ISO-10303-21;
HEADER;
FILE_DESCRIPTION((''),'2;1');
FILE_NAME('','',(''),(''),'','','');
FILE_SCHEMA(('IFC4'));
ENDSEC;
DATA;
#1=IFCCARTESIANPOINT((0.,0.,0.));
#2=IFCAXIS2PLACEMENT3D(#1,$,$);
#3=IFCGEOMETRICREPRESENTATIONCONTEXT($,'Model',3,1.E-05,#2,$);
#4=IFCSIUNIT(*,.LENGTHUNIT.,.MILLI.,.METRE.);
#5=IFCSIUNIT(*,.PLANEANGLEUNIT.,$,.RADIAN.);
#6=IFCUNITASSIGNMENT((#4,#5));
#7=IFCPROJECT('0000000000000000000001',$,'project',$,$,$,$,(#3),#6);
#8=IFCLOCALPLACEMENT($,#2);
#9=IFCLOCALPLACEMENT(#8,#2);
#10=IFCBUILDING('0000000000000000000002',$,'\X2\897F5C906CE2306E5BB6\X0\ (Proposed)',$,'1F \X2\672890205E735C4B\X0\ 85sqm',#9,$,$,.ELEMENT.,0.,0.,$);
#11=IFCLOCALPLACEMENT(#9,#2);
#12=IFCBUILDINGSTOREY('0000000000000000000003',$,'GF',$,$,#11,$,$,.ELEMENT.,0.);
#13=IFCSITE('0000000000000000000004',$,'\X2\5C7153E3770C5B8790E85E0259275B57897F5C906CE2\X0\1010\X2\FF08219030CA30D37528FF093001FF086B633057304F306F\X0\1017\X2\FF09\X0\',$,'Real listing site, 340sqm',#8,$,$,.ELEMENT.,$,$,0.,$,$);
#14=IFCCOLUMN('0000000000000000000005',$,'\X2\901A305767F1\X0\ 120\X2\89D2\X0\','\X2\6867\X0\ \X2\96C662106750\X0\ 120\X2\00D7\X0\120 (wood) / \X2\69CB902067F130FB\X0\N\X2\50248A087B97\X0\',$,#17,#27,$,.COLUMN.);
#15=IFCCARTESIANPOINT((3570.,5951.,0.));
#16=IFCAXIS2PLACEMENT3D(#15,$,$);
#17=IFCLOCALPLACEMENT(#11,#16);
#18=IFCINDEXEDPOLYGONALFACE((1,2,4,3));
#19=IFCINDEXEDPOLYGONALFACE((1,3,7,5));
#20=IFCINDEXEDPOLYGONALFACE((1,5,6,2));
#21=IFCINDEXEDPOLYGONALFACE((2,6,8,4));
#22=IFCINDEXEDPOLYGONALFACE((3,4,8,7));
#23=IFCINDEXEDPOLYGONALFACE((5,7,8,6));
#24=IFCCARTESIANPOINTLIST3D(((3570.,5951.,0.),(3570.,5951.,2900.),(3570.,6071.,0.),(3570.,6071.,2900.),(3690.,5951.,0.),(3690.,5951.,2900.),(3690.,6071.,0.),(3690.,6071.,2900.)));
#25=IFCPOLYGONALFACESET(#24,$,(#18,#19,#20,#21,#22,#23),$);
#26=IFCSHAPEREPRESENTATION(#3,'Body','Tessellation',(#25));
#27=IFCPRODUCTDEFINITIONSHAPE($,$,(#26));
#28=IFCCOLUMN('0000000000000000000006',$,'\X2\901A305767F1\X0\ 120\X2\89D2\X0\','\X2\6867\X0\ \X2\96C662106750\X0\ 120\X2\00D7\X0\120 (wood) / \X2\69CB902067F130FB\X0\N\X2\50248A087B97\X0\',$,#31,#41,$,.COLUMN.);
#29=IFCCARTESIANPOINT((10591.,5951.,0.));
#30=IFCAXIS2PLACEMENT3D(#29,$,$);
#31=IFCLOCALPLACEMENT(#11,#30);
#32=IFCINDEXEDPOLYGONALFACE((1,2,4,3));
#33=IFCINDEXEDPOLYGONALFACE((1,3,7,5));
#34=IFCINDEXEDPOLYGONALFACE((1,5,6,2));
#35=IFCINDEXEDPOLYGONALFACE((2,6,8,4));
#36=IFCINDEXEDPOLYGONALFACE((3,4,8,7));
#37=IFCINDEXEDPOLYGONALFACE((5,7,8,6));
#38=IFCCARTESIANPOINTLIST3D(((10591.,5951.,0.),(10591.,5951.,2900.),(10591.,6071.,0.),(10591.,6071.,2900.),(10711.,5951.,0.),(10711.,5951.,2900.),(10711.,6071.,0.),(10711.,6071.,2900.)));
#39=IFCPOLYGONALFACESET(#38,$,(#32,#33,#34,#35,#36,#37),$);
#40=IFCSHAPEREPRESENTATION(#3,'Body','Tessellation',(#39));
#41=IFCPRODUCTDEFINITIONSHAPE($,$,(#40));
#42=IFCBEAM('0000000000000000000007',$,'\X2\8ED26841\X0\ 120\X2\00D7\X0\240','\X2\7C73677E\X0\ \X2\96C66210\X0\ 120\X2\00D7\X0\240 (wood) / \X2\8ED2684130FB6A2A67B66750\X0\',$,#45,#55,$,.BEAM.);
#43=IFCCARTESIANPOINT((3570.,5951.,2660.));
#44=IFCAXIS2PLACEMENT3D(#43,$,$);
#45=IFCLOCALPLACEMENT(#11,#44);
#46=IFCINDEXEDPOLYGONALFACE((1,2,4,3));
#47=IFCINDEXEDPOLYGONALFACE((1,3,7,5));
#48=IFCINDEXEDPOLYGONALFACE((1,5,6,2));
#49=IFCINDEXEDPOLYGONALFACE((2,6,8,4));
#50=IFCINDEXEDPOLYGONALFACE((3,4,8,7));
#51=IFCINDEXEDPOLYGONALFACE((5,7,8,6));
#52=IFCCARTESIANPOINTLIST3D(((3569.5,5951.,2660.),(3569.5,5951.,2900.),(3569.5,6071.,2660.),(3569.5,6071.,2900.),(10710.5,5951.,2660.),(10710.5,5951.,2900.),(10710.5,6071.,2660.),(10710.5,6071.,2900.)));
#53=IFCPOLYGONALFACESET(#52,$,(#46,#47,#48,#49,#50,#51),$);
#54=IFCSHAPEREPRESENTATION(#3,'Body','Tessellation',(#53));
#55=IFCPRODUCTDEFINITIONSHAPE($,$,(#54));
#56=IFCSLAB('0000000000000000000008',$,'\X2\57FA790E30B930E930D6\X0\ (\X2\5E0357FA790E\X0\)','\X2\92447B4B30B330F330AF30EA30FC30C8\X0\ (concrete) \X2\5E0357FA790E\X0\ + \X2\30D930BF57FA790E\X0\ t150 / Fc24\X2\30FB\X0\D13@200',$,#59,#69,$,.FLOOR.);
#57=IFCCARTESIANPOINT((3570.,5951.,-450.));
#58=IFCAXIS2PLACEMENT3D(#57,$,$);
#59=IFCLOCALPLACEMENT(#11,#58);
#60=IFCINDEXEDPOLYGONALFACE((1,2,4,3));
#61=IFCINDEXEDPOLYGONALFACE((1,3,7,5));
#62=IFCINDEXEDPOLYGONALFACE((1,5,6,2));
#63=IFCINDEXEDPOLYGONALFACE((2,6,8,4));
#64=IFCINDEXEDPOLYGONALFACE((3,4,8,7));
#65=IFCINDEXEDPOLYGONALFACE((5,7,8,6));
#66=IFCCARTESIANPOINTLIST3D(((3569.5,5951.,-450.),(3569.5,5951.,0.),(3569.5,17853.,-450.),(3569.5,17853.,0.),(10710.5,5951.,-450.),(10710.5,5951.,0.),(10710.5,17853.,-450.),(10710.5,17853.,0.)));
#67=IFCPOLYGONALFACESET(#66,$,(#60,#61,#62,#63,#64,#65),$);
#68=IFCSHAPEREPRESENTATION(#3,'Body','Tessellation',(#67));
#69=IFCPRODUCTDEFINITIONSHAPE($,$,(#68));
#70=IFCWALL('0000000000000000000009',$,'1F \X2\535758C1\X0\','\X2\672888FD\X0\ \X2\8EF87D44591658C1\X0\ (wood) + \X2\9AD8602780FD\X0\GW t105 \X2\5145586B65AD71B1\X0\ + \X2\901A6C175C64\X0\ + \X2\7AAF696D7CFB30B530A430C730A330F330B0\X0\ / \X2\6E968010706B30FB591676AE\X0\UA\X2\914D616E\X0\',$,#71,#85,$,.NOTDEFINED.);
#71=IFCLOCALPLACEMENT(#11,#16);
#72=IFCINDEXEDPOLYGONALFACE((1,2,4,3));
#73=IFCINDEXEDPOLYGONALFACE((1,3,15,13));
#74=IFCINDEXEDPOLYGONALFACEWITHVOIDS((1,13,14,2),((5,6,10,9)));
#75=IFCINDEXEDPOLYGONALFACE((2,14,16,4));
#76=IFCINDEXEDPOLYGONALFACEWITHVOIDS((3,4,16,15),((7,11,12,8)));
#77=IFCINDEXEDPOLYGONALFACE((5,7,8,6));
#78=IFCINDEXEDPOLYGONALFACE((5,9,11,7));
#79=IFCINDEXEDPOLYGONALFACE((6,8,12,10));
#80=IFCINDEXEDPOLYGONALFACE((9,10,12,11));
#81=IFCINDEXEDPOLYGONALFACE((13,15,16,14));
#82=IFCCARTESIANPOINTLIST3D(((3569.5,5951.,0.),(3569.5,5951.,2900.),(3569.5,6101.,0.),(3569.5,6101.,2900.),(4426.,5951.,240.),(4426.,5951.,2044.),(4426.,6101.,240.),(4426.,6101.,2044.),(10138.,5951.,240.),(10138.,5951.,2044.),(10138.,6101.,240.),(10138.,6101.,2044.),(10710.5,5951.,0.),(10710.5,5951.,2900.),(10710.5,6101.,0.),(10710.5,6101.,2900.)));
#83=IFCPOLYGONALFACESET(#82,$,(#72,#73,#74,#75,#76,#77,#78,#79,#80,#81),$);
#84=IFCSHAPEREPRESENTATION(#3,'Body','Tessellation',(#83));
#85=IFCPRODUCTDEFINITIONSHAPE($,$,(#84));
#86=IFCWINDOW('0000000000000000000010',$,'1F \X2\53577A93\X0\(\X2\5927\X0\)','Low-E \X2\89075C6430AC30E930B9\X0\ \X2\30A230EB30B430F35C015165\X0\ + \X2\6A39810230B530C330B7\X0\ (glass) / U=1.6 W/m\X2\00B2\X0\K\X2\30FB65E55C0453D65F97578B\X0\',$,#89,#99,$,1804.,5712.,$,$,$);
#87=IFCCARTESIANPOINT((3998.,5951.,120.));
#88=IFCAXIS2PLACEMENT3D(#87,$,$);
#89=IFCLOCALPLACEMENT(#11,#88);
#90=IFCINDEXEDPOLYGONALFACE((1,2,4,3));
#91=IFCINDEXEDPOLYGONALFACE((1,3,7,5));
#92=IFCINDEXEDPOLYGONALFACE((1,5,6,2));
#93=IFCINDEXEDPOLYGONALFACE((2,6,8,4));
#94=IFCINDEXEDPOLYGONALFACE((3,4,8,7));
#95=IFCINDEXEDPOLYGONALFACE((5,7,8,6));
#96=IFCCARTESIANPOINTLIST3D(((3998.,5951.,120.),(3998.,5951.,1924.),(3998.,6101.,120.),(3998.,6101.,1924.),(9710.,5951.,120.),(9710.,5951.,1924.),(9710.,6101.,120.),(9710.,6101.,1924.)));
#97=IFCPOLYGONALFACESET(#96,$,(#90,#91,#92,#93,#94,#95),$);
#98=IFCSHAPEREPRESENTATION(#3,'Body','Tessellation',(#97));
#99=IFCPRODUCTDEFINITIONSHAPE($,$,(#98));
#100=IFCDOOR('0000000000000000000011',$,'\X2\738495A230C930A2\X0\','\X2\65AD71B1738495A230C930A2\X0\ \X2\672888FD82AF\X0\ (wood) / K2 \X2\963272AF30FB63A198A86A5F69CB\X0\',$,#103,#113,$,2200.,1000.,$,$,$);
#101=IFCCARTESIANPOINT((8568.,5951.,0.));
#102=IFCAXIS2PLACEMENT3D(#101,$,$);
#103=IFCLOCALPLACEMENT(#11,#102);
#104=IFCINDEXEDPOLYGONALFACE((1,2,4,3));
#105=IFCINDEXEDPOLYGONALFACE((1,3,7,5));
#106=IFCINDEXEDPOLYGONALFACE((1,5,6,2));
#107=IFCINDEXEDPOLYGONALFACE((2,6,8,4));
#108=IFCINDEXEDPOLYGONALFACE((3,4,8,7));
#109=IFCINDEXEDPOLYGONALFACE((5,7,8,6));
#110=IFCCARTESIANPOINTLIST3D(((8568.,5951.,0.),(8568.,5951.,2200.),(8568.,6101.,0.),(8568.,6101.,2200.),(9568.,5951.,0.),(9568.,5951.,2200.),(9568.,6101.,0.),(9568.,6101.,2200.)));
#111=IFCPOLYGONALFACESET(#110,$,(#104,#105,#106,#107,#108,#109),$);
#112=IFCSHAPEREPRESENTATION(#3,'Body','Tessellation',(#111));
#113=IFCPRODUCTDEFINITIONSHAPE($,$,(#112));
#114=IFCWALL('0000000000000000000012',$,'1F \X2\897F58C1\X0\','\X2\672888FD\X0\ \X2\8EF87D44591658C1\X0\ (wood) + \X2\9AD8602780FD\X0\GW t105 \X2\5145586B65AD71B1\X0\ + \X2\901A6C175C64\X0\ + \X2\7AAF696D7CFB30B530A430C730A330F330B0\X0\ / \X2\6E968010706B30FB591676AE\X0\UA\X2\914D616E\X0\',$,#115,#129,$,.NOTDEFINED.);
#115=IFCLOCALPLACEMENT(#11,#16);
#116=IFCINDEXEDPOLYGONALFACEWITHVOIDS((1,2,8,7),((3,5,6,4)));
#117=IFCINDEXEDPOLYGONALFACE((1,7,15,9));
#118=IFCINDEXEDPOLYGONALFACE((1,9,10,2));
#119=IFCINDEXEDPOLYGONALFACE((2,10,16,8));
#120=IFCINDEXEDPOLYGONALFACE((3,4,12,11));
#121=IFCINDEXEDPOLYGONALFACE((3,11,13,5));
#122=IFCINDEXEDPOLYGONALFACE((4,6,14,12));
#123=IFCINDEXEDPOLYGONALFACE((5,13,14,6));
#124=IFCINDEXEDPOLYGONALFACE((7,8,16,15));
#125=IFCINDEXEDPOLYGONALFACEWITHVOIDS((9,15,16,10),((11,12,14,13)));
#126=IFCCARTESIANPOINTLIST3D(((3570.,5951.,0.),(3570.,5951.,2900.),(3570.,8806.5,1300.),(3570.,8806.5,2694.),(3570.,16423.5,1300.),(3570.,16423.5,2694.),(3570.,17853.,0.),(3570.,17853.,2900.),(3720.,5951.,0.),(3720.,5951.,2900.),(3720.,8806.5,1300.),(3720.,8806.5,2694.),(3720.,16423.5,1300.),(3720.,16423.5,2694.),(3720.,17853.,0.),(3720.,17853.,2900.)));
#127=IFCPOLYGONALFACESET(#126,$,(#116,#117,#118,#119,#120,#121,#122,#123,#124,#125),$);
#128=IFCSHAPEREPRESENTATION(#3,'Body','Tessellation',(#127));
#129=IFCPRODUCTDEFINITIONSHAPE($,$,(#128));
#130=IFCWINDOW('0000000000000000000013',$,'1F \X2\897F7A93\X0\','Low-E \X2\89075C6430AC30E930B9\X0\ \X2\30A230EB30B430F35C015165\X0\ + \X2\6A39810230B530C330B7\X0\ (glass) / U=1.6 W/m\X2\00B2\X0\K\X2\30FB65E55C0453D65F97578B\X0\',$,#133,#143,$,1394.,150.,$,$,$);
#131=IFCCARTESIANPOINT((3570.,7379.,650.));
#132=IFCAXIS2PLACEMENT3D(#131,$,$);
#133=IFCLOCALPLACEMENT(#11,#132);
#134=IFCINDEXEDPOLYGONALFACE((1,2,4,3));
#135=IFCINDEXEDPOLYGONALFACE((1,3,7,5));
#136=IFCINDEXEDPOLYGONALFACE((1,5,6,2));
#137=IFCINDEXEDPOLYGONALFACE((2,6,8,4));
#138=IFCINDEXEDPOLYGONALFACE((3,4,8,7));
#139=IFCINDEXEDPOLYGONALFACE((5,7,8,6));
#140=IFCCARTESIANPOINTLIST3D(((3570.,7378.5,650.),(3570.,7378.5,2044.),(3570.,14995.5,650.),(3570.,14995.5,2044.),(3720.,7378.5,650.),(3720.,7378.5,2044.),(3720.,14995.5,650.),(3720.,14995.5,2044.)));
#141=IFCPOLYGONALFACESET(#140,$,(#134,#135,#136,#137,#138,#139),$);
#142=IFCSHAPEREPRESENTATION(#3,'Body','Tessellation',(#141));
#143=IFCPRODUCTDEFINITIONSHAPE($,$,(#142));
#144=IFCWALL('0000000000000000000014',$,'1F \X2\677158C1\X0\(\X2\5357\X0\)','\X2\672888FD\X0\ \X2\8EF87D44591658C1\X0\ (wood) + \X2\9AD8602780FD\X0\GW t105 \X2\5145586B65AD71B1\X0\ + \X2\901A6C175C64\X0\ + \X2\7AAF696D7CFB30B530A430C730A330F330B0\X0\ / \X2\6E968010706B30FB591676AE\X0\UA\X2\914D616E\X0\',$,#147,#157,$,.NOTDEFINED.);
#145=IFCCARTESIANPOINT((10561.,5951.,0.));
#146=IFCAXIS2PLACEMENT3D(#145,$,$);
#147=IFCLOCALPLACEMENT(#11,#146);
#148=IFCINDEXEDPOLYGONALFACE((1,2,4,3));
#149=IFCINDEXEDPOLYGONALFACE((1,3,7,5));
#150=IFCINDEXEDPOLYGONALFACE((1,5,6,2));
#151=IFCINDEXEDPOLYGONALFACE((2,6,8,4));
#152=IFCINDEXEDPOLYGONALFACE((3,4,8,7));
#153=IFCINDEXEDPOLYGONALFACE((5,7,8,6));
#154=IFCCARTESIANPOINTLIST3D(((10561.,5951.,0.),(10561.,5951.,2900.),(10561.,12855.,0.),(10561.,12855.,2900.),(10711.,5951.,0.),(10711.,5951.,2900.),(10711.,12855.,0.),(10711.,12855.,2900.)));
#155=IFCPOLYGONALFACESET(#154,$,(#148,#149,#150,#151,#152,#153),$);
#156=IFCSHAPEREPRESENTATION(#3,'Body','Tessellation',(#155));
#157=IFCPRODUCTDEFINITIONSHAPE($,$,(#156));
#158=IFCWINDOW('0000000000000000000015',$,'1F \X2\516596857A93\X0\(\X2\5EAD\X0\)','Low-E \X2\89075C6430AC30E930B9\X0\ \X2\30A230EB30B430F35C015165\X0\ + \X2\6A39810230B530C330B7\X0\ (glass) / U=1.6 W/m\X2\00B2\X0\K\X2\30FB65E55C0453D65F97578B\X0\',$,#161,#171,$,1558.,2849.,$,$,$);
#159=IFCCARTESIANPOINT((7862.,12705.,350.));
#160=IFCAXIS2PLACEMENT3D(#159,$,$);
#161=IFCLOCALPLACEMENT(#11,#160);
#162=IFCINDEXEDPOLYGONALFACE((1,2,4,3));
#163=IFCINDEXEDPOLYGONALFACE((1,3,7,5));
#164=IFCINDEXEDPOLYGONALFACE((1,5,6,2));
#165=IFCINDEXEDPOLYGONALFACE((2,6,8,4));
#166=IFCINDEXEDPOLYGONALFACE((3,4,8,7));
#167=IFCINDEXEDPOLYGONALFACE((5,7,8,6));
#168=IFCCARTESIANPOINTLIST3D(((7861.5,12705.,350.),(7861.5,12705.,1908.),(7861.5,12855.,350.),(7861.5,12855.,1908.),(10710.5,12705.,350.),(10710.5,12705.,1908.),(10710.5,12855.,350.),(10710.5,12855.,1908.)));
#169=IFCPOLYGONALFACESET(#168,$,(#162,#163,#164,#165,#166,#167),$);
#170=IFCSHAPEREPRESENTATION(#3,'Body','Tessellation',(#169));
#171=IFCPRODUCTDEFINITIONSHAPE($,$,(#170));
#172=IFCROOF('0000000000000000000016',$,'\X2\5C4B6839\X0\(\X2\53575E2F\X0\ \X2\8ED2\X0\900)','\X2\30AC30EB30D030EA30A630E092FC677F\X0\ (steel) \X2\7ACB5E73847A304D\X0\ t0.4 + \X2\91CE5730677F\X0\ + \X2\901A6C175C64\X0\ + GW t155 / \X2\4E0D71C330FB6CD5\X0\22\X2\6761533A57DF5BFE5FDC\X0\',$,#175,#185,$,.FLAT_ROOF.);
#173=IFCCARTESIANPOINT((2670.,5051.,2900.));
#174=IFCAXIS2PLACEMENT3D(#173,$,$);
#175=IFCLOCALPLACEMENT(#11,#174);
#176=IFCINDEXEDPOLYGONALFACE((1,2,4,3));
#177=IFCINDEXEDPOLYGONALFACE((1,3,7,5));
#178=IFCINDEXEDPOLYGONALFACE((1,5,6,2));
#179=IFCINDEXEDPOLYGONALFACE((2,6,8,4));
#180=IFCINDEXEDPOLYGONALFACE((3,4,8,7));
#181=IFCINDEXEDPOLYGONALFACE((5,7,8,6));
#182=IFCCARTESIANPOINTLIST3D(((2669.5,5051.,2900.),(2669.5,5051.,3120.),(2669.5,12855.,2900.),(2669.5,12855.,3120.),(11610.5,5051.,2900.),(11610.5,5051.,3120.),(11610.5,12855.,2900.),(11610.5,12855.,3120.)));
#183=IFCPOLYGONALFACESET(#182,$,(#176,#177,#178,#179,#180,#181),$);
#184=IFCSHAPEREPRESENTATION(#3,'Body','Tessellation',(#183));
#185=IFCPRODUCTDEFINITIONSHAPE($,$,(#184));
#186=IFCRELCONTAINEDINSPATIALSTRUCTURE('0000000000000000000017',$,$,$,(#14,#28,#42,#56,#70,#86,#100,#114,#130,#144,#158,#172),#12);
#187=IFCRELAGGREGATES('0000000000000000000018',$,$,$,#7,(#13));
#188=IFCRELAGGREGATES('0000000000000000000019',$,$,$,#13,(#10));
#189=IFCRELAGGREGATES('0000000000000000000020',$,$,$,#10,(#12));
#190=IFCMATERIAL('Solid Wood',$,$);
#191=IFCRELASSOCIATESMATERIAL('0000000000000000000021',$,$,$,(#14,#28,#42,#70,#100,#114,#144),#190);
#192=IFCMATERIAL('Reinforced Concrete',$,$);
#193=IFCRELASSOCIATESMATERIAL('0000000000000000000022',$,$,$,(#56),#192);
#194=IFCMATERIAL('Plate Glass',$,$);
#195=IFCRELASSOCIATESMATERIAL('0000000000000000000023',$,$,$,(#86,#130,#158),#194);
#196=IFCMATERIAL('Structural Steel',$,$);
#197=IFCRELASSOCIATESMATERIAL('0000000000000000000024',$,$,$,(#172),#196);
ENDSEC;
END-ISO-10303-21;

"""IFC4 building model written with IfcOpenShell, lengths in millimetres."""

from ifc_helpers import new_model, si_unit, frame, frame_2d, origin, place, context, project, spatial, rectangle, extrude, material, element, fill, save


model = new_model("IFC4")

# Units and contexts
model_context = context("Model", 3, precision=1e-05, world=origin())
ifc_project = project(units=[si_unit("LENGTHUNIT", "METRE", prefix="MILLI"), si_unit("PLANEANGLEUNIT", "RADIAN")], contexts=[model_context])

# Site, building, storey
site_placement = place(None, origin())
site = spatial("IfcSite", under=ifc_project, at=site_placement, Name="山口県宇部市大字西岐波1010（←ナビ用）、（正しくは1017）", ObjectType="Real listing site, 340sqm", CompositionType="ELEMENT", RefElevation=0.0)
building_placement = place(site_placement, origin())
building = spatial("IfcBuilding", under=site, at=building_placement, Name="西岐波の家 (Proposed)", ObjectType="1F 木造平屋 85sqm", CompositionType="ELEMENT", ElevationOfRefHeight=0.0, ElevationOfTerrain=0.0)
storey_placement = place(building_placement, origin())
storey = spatial("IfcBuildingStorey", under=building, at=storey_placement, Name="GF", CompositionType="ELEMENT", Elevation=0.0)

# Columns
ifc_material_1 = material(Name="Solid Wood")
column_1_placement = place(storey_placement, frame((3570.0, 5951.0, 0.0)))
element("IfcColumn", 1, at=column_1_placement, inside=storey, material=ifc_material_1, Name="通し柱 120角", Description="桧 集成材 120×120 (wood) / 構造柱・N値計算", PredefinedType="COLUMN", context=model_context, shape_type="SweptSolid", body=[
    extrude(rectangle(XDim=120.0, YDim=120.0, at=frame_2d((60.0, 60.0))), frame((3570.0, 5951.0, 0.0)), (0.0, 0.0, 1.0), 2900.0),
])
column_2_placement = place(storey_placement, frame((10591.0, 5951.0, 0.0)))
element("IfcColumn", 2, at=column_2_placement, inside=storey, material=ifc_material_1, Name="通し柱 120角", Description="桧 集成材 120×120 (wood) / 構造柱・N値計算", PredefinedType="COLUMN", context=model_context, shape_type="SweptSolid", body=[
    extrude(rectangle(XDim=120.0, YDim=120.0, at=frame_2d((60.0, 60.0))), frame((10591.0, 5951.0, 0.0)), (0.0, 0.0, 1.0), 2900.0),
])

# Beam
beam_1_placement = place(storey_placement, frame((3570.0, 5951.0, 2660.0)))
element("IfcBeam", 3, at=beam_1_placement, inside=storey, material=ifc_material_1, Name="軒桁 120×240", Description="米松 集成 120×240 (wood) / 軒桁・横架材", PredefinedType="BEAM", context=model_context, shape_type="SweptSolid", body=[
    extrude(rectangle(XDim=7141.0, YDim=120.0, at=frame_2d((3570.0, 60.0))), frame((3570.0, 5951.0, 2660.0)), (0.0, 0.0, 1.0), 240.0),
])

# Slab
ifc_material_2 = material(Name="Reinforced Concrete")
slab_1_placement = place(storey_placement, frame((3570.0, 5951.0, -450.0)))
element("IfcSlab", 4, at=slab_1_placement, inside=storey, material=ifc_material_2, Name="基礎スラブ (布基礎)", Description="鉄筋コンクリート (concrete) 布基礎 + ベタ基礎 t150 / Fc24・D13@200", PredefinedType="FLOOR", context=model_context, shape_type="SweptSolid", body=[
    extrude(rectangle(XDim=7141.0, YDim=11902.0, at=frame_2d((3570.0, 5951.0))), frame((3570.0, 5951.0, -450.0)), (0.0, 0.0, 1.0), 450.0),
])

# Wall, openings, window, door
wall_1_placement = place(storey_placement, frame((3570.0, 5951.0, 0.0)))
wall_1 = element("IfcWall", 5, at=wall_1_placement, inside=storey, material=ifc_material_1, Name="1F 南壁", Description="木製 軸組外壁 (wood) + 高性能GW t105 充填断熱 + 通気層 + 窯業系サイディング / 準耐火・外皮UA配慮", PredefinedType="NOTDEFINED", context=model_context, shape_type="SweptSolid", body=[
    extrude(rectangle(XDim=7141.0, YDim=150.0, at=frame_2d((3570.0, 75.0))), frame((3570.0, 5951.0, 0.0)), (0.0, 0.0, 1.0), 2900.0),
])
opening_1_placement = place(storey_placement, frame((3998.0, 5951.0, 120.0)))
opening_1 = element("IfcOpeningElement", 6, at=opening_1_placement, cuts=wall_1, PredefinedType="NOTDEFINED", context=model_context, shape_type="SweptSolid", body=[
    extrude(rectangle(XDim=5712.0, YDim=150.0, at=frame_2d((2856.0, 75.0))), frame((3998.0, 5951.0, 120.0)), (0.0, 0.0, 1.0), 1804.0),
])
opening_2_placement = place(storey_placement, frame((8568.0, 5951.0, 0.0)))
opening_2 = element("IfcOpeningElement", 7, at=opening_2_placement, cuts=wall_1, PredefinedType="NOTDEFINED", context=model_context, shape_type="SweptSolid", body=[
    extrude(rectangle(XDim=1000.0, YDim=150.0, at=frame_2d((500.0, 75.0))), frame((8568.0, 5951.0, 0.0)), (0.0, 0.0, 1.0), 2200.0),
])
ifc_material_3 = material(Name="Plate Glass")
window_1_placement = place(storey_placement, frame((3998.0, 5951.0, 120.0)))
window_1 = element("IfcWindow", 8, at=window_1_placement, inside=storey, material=ifc_material_3, Name="1F 南窓(大)", Description="Low-E 複層ガラス アルゴン封入 + 樹脂サッシ (glass) / U=1.6 W/m²K・日射取得型", OverallHeight=1804.0, OverallWidth=5712.0, context=model_context, shape_type="SweptSolid", body=[
    extrude(rectangle(XDim=5712.0, YDim=150.0, at=frame_2d((2856.0, 75.0))), frame((3998.0, 5951.0, 120.0)), (0.0, 0.0, 1.0), 1804.0),
])
fill(opening_1, window_1)
door_1_placement = place(storey_placement, frame((8568.0, 5951.0, 0.0)))
door_1 = element("IfcDoor", 9, at=door_1_placement, inside=storey, material=ifc_material_1, Name="玄関ドア", Description="断熱玄関ドア 木製芯 (wood) / K2 防犯・採風機構", OverallHeight=2200.0, OverallWidth=1000.0, context=model_context, shape_type="SweptSolid", body=[
    extrude(rectangle(XDim=1000.0, YDim=150.0, at=frame_2d((500.0, 75.0))), frame((8568.0, 5951.0, 0.0)), (0.0, 0.0, 1.0), 2200.0),
])
fill(opening_2, door_1)

# Walls, openings, windows
wall_2_placement = place(storey_placement, frame((3570.0, 5951.0, 0.0)))
wall_2 = element("IfcWall", 10, at=wall_2_placement, inside=storey, material=ifc_material_1, Name="1F 西壁", Description="木製 軸組外壁 (wood) + 高性能GW t105 充填断熱 + 通気層 + 窯業系サイディング / 準耐火・外皮UA配慮", PredefinedType="NOTDEFINED", context=model_context, shape_type="SweptSolid", body=[
    extrude(rectangle(XDim=150.0, YDim=11902.0, at=frame_2d((75.0, 5951.0))), frame((3570.0, 5951.0, 0.0)), (0.0, 0.0, 1.0), 2900.0),
])
opening_3_placement = place(storey_placement, frame((3570.0, 7379.0, 650.0)))
opening_3 = element("IfcOpeningElement", 11, at=opening_3_placement, cuts=wall_2, PredefinedType="NOTDEFINED", context=model_context, shape_type="SweptSolid", body=[
    extrude(rectangle(XDim=150.0, YDim=7617.0, at=frame_2d((75.0, 3808.0))), frame((3570.0, 7379.0, 650.0)), (0.0, 0.0, 1.0), 1394.0),
])
window_2_placement = place(storey_placement, frame((3570.0, 7379.0, 650.0)))
window_2 = element("IfcWindow", 12, at=window_2_placement, inside=storey, material=ifc_material_3, Name="1F 西窓", Description="Low-E 複層ガラス アルゴン封入 + 樹脂サッシ (glass) / U=1.6 W/m²K・日射取得型", OverallHeight=1394.0, OverallWidth=150.0, context=model_context, shape_type="SweptSolid", body=[
    extrude(rectangle(XDim=150.0, YDim=7617.0, at=frame_2d((75.0, 3808.0))), frame((3570.0, 7379.0, 650.0)), (0.0, 0.0, 1.0), 1394.0),
])
fill(opening_3, window_2)
wall_3_placement = place(storey_placement, frame((10561.0, 5951.0, 0.0)))
wall_3 = element("IfcWall", 13, at=wall_3_placement, inside=storey, material=ifc_material_1, Name="1F 東壁(南)", Description="木製 軸組外壁 (wood) + 高性能GW t105 充填断熱 + 通気層 + 窯業系サイディング / 準耐火・外皮UA配慮", PredefinedType="NOTDEFINED", context=model_context, shape_type="SweptSolid", body=[
    extrude(rectangle(XDim=150.0, YDim=6904.0, at=frame_2d((75.0, 3452.0))), frame((10561.0, 5951.0, 0.0)), (0.0, 0.0, 1.0), 2900.0),
])
opening_4_placement = place(storey_placement, frame((7862.0, 12705.0, 350.0)))
opening_4 = element("IfcOpeningElement", 14, at=opening_4_placement, cuts=wall_3, PredefinedType="NOTDEFINED", context=model_context, shape_type="SweptSolid", body=[
    extrude(rectangle(XDim=2849.0, YDim=150.0, at=frame_2d((1424.0, 75.0))), frame((7862.0, 12705.0, 350.0)), (0.0, 0.0, 1.0), 1558.0),
])
window_3_placement = place(storey_placement, frame((7862.0, 12705.0, 350.0)))
window_3 = element("IfcWindow", 15, at=window_3_placement, inside=storey, material=ifc_material_3, Name="1F 入隅窓(庭)", Description="Low-E 複層ガラス アルゴン封入 + 樹脂サッシ (glass) / U=1.6 W/m²K・日射取得型", OverallHeight=1558.0, OverallWidth=2849.0, context=model_context, shape_type="SweptSolid", body=[
    extrude(rectangle(XDim=2849.0, YDim=150.0, at=frame_2d((1424.0, 75.0))), frame((7862.0, 12705.0, 350.0)), (0.0, 0.0, 1.0), 1558.0),
])
fill(opening_4, window_3)

# Roof
ifc_material_4 = material(Name="Structural Steel")
roof_placement = place(storey_placement, frame((2670.0, 5051.0, 2900.0)))
element("IfcRoof", 16, at=roof_placement, inside=storey, material=ifc_material_4, Name="屋根(南帯 軒900)", Description="ガルバリウム鋼板 (steel) 立平葺き t0.4 + 野地板 + 通気層 + GW t155 / 不燃・法22条区域対応", PredefinedType="FLAT_ROOF", context=model_context, shape_type="SweptSolid", body=[
    extrude(rectangle(XDim=8941.0, YDim=7804.0, at=frame_2d((4470.0, 3902.0))), frame((2670.0, 5051.0, 2900.0)), (0.0, 0.0, 1.0), 220.0),
])

save(model, "model.ifc")
